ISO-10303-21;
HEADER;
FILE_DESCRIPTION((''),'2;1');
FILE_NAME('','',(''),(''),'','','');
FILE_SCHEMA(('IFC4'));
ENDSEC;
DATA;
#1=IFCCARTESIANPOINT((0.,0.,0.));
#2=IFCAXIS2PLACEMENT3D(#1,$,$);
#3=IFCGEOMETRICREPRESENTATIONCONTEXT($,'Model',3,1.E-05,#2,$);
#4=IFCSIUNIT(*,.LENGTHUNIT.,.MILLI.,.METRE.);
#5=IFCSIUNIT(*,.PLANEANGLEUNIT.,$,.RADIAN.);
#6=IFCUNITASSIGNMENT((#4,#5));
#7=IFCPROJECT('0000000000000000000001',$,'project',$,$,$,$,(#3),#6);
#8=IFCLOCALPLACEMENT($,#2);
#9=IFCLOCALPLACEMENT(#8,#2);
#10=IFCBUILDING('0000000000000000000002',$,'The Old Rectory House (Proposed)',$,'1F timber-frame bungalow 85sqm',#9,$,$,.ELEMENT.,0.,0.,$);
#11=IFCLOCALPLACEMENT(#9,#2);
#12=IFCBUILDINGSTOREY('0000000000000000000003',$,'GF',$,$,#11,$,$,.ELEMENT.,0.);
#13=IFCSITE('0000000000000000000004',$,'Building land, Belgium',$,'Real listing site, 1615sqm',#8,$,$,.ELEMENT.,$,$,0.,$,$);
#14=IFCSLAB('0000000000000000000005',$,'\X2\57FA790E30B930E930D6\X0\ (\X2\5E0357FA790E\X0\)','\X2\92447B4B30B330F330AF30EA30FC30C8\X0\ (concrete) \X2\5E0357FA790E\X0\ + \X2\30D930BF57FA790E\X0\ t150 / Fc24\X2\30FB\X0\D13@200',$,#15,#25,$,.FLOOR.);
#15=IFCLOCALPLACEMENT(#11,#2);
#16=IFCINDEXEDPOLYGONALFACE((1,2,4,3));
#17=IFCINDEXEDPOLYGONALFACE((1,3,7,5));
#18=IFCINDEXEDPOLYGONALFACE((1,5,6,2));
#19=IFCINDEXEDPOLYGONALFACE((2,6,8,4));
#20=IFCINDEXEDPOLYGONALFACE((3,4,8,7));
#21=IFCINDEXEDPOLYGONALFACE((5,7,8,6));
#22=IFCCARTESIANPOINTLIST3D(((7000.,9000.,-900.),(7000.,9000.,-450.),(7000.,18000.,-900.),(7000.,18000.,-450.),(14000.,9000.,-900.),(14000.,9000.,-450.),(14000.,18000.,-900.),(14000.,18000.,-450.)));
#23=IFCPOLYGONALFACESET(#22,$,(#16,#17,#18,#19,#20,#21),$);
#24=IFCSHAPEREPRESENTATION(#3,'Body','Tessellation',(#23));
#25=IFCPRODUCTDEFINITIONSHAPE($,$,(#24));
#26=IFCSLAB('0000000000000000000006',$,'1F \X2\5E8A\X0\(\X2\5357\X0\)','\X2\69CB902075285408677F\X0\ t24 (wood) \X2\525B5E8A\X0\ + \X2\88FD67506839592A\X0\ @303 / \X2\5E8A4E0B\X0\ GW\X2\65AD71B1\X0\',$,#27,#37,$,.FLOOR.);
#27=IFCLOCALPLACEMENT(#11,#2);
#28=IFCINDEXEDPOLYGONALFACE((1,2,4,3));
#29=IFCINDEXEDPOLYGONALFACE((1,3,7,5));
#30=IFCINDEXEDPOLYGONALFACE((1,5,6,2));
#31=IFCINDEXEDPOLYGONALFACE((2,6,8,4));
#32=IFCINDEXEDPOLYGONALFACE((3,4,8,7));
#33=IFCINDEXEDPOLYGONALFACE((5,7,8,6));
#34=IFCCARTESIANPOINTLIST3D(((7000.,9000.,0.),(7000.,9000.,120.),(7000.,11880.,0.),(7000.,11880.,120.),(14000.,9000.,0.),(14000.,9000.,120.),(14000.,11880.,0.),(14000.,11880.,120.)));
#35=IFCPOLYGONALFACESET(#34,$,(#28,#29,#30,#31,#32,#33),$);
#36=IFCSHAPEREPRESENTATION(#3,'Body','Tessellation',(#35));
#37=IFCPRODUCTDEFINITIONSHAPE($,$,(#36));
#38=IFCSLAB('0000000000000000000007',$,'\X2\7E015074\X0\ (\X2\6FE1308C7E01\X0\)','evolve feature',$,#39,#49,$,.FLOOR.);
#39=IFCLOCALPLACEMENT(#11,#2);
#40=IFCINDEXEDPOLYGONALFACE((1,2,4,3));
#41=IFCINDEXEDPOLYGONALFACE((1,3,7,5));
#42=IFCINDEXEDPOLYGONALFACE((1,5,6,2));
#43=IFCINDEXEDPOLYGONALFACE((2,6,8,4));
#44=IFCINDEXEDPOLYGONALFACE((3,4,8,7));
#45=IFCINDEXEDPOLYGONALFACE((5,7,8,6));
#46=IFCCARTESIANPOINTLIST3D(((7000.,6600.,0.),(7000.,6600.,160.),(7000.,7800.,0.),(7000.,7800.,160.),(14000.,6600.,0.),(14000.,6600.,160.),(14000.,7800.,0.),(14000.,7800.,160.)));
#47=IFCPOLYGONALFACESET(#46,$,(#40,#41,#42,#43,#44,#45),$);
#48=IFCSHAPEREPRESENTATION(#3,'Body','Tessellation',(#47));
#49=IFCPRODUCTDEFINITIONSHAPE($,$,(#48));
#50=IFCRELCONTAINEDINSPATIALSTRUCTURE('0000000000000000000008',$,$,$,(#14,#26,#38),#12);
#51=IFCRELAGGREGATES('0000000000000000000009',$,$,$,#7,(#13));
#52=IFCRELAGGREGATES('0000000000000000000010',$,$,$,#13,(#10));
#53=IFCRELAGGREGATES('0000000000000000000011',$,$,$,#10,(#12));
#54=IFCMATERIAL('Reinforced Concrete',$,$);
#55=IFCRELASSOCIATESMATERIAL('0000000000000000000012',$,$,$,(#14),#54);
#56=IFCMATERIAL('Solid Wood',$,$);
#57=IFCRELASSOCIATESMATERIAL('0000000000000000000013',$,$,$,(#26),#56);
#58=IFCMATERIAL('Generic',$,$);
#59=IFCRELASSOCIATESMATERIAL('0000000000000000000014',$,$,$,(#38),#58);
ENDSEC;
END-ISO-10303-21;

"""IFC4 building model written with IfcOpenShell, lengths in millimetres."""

from ifc_helpers import new_model, si_unit, frame, frame_2d, origin, place, context, project, spatial, rectangle, extrude, material, element, save


model = new_model("IFC4")

# Units and contexts
model_context = context("Model", 3, precision=1e-05, world=origin())
ifc_project = project(units=[si_unit("LENGTHUNIT", "METRE", prefix="MILLI"), si_unit("PLANEANGLEUNIT", "RADIAN")], contexts=[model_context])

# Site, building, storey
site_placement = place(None, origin())
site = spatial("IfcSite", under=ifc_project, at=site_placement, Name="Building land, Belgium", ObjectType="Real listing site, 1615sqm", CompositionType="ELEMENT", RefElevation=0.0)
building_placement = place(site_placement, origin())
building = spatial("IfcBuilding", under=site, at=building_placement, Name="The Old Rectory House (Proposed)", ObjectType="1F timber-frame bungalow 85sqm", CompositionType="ELEMENT", ElevationOfRefHeight=0.0, ElevationOfTerrain=0.0)
storey_placement = place(building_placement, origin())
storey = spatial("IfcBuildingStorey", under=building, at=storey_placement, Name="GF", CompositionType="ELEMENT", Elevation=0.0)

# Slabs
ifc_material_1 = material(Name="Reinforced Concrete")
slab_1_placement = place(storey_placement, frame((3500.0, 4500.0, -450.0)))
element("IfcSlab", 1, at=slab_1_placement, inside=storey, material=ifc_material_1, Name="基礎スラブ (布基礎)", Description="鉄筋コンクリート (concrete) 布基礎 + ベタ基礎 t150 / Fc24・D13@200", PredefinedType="FLOOR", context=model_context, shape_type="SweptSolid", body=[
    extrude(rectangle(XDim=7000.0, YDim=9000.0, at=frame_2d((3500.0, 4500.0))), frame((3500.0, 4500.0, -450.0)), (0.0, 0.0, 1.0), 450.0),
])
ifc_material_2 = material(Name="Solid Wood")
slab_2_placement = place(storey_placement, frame((3500.0, 4500.0, 0.0)))
element("IfcSlab", 2, at=slab_2_placement, inside=storey, material=ifc_material_2, Name="1F 床(南)", Description="構造用合板 t24 (wood) 剛床 + 製材根太 @303 / 床下 GW断熱", PredefinedType="FLOOR", context=model_context, shape_type="SweptSolid", body=[
    extrude(rectangle(XDim=7000.0, YDim=2880.0, at=frame_2d((3500.0, 1440.0))), frame((3500.0, 4500.0, 0.0)), (0.0, 0.0, 1.0), 120.0),
])
ifc_material_3 = material(Name="Generic")
slab_3_placement = place(storey_placement, frame((3500.0, 3300.0, 0.0)))
element("IfcSlab", 3, at=slab_3_placement, inside=storey, material=ifc_material_3, Name="縁側 (濡れ縁)", Description="evolve feature", PredefinedType="FLOOR", context=model_context, shape_type="SweptSolid", body=[
    extrude(rectangle(XDim=7000.0, YDim=1200.0, at=frame_2d((3500.0, 600.0))), frame((3500.0, 3300.0, 0.0)), (0.0, 0.0, 1.0), 160.0),
])

save(model, "model.ifc")
